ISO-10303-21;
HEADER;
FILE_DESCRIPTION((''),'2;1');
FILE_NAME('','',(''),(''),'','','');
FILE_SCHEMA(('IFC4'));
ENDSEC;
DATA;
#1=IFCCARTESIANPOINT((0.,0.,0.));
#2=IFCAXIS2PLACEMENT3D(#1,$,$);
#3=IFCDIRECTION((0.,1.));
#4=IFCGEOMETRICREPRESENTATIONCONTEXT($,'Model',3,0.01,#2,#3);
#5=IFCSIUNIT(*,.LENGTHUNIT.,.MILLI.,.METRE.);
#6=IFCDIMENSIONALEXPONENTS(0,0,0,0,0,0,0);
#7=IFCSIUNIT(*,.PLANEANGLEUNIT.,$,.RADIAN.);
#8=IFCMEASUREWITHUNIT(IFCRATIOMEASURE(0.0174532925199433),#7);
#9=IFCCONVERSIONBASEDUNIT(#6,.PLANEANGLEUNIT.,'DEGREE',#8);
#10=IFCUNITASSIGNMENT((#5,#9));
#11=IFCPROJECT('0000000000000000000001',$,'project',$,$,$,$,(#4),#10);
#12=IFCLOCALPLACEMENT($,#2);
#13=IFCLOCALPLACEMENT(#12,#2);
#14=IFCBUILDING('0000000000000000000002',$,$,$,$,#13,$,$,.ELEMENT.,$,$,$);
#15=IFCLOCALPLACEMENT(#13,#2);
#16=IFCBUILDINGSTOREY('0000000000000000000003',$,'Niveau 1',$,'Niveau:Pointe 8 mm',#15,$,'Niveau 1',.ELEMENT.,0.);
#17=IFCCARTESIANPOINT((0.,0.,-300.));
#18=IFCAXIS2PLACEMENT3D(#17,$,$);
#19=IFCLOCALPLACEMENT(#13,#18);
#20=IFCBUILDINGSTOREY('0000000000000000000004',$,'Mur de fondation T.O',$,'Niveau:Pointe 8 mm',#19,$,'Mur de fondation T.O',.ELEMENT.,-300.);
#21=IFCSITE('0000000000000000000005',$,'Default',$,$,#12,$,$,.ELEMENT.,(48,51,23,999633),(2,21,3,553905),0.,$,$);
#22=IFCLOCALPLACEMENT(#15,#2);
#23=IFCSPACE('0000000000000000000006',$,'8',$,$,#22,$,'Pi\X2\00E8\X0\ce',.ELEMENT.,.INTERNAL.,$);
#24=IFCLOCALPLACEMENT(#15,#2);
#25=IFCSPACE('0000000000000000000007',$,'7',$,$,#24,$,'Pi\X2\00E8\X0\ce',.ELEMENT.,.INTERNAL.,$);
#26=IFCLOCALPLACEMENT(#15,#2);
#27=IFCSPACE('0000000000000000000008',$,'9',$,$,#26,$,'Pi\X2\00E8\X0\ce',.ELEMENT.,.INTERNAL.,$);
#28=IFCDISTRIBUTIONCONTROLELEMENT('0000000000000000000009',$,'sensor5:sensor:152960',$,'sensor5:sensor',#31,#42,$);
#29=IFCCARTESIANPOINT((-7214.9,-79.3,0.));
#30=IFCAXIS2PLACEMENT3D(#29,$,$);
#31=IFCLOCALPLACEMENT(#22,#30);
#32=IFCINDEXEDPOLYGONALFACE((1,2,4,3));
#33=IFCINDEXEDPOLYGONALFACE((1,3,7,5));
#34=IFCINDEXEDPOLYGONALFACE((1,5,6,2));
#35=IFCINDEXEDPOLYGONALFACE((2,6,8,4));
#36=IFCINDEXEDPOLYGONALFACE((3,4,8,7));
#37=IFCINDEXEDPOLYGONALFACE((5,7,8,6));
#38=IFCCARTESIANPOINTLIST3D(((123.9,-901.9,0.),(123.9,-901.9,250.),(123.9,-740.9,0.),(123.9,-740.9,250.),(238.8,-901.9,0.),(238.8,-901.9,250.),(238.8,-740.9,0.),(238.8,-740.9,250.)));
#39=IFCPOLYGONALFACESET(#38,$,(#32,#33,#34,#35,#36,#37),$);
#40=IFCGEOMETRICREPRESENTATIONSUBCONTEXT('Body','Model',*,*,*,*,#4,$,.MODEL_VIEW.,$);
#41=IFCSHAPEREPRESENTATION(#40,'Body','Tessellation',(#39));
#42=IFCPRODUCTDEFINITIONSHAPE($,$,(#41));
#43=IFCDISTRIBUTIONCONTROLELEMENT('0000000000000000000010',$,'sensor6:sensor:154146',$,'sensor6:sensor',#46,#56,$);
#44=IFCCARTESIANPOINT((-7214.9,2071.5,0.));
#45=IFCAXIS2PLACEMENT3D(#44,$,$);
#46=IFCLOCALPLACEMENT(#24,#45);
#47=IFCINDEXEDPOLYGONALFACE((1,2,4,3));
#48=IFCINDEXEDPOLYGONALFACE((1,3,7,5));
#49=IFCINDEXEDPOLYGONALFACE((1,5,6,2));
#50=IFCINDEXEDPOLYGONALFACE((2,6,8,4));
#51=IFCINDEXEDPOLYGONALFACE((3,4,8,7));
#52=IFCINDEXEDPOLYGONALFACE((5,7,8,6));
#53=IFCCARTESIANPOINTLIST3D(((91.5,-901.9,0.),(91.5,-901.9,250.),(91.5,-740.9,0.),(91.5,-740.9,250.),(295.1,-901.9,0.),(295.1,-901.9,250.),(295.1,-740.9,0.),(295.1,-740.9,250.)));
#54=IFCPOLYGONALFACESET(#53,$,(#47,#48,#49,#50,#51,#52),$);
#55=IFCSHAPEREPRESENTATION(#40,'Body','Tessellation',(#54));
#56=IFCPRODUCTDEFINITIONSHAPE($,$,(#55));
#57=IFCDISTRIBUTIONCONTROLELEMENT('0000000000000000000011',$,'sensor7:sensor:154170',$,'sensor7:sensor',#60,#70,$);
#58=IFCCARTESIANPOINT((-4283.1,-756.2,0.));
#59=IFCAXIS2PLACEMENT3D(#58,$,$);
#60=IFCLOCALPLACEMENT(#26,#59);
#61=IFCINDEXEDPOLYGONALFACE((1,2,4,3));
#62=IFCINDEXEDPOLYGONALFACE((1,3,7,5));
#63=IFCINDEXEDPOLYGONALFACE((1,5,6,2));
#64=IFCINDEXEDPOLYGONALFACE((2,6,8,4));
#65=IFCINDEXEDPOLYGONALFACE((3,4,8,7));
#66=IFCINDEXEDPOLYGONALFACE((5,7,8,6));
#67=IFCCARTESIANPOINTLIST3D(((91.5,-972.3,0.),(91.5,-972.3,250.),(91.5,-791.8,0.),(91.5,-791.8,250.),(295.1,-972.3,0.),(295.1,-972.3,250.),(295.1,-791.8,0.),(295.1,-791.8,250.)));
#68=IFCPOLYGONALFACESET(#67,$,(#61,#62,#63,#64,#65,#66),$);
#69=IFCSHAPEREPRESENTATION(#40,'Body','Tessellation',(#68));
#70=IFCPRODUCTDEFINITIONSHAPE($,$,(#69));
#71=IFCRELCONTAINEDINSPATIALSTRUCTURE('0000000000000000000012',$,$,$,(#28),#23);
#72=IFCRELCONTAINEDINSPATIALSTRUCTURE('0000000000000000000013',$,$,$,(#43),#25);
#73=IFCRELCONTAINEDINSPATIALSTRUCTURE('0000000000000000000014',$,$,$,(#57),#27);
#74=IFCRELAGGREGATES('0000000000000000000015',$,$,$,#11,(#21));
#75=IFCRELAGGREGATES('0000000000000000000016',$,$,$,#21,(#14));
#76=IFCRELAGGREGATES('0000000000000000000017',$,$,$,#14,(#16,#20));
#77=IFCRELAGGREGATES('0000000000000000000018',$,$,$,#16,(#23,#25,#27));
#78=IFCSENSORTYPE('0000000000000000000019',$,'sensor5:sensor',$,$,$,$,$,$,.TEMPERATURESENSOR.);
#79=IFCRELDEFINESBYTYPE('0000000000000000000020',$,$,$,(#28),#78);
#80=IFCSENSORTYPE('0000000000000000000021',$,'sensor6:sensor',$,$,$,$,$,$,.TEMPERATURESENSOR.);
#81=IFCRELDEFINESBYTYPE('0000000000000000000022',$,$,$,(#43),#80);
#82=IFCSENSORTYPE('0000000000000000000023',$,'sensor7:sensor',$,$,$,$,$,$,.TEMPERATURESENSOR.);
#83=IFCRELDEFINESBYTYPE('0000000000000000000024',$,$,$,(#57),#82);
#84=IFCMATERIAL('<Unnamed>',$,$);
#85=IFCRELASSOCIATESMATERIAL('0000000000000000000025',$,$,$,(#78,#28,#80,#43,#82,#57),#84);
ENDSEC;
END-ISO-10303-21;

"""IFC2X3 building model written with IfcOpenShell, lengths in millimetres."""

from ifc_helpers import new_model, entity, si_unit, converted_unit, direction, frame, origin, origin_2d_with_axis, place, context, subcontext, project, spatial, rectangle, extrude, source, transform, mapped, material, type_object, type_shapes, element, save


model = new_model("IFC2X3")

# Units and contexts
model_context = context("Model", 3, precision=0.01, world=origin(), true_north=direction((0.0, 1.0)))
body_context = subcontext(model_context, "Body", "Model", "MODEL_VIEW")
ifc_project = project(units=[si_unit("LENGTHUNIT", "METRE", prefix="MILLI"), converted_unit("PLANEANGLEUNIT", "DEGREE", entity("IfcRatioMeasure", 0.0174532925199433), si_unit("PLANEANGLEUNIT", "RADIAN"), dimensions=[0, 0, 0, 0, 0, 0, 0])], contexts=[model_context])

# Site, building, storey
site_placement = place(None, origin())
site = spatial("IfcSite", under=ifc_project, at=site_placement, Name="Default", CompositionType="ELEMENT", RefLatitude=(48, 51, 23, 999633), RefLongitude=(2, 21, 3, 553905), RefElevation=0.0)
building_placement = place(site_placement, origin())
building = spatial("IfcBuilding", under=site, at=building_placement, CompositionType="ELEMENT")
storey_1_placement = place(building_placement, origin())
storey_1 = spatial("IfcBuildingStorey", under=building, at=storey_1_placement, Name="Niveau 1", ObjectType="Niveau:Pointe 8 mm", LongName="Niveau 1", CompositionType="ELEMENT", Elevation=0.0)

# Shared definitions
storey_2_placement = place(building_placement, frame((0.0, 0.0, -300.0)))
storey_2 = spatial("IfcBuildingStorey", under=building, at=storey_2_placement, Name="Mur de fondation T.O", ObjectType="Niveau:Pointe 8 mm", LongName="Mur de fondation T.O", CompositionType="ELEMENT", Elevation=-300.0)

# Shared definitions
ifc_material_1 = material(Name="<Unnamed>")

# Shared definitions
space_1_placement = place(storey_1_placement, origin())
space_1 = spatial("IfcSpace", under=storey_1, at=space_1_placement, Name="8", LongName="Pièce", CompositionType="ELEMENT", InteriorOrExteriorSpace="INTERNAL")

# Distribution control element
sensor_type_1 = type_object("IfcSensorType", Name="sensor5:sensor", PredefinedType="TEMPERATURESENSOR", material=ifc_material_1)
shared_shape_1 = source(origin(), body_context, "Body", "SweptSolid", [
    extrude(rectangle(XDim=114.9, YDim=161.0, at=origin_2d_with_axis()), frame((181.3, -821.4, 0.0), z_axis=(0.0, 0.0, 1.0), x_axis=(-1.0, 0.0, 0.0)), (0.0, 0.0, 1.0), 250.0),
])
type_shapes(sensor_type_1, [shared_shape_1])
distribution_control_element_1_placement = place(space_1_placement, frame((-7214.9, -79.3, 0.0)))
element("IfcDistributionControlElement", 1, at=distribution_control_element_1_placement, inside=space_1, type_object=sensor_type_1, material=ifc_material_1, Name="sensor5:sensor:152960", ObjectType="sensor5:sensor", context=body_context, shape_type="MappedRepresentation", body=[
    mapped(shared_shape_1, transform((0.0, 0.0, 0.0), scale=1.0)),
])

# Shared definitions
space_2_placement = place(storey_1_placement, origin())
space_2 = spatial("IfcSpace", under=storey_1, at=space_2_placement, Name="7", LongName="Pièce", CompositionType="ELEMENT", InteriorOrExteriorSpace="INTERNAL")

# Distribution control element
sensor_type_2 = type_object("IfcSensorType", Name="sensor6:sensor", PredefinedType="TEMPERATURESENSOR", material=ifc_material_1)
shared_shape_2 = source(origin(), body_context, "Body", "SweptSolid", [
    extrude(rectangle(XDim=203.6, YDim=161.0, at=origin_2d_with_axis()), frame((193.3, -821.4, 0.0), z_axis=(0.0, 0.0, 1.0), x_axis=(-1.0, 0.0, 0.0)), (0.0, 0.0, 1.0), 250.0),
])
type_shapes(sensor_type_2, [shared_shape_2])
distribution_control_element_2_placement = place(space_2_placement, frame((-7214.9, 2071.5, 0.0)))
element("IfcDistributionControlElement", 2, at=distribution_control_element_2_placement, inside=space_2, type_object=sensor_type_2, material=ifc_material_1, Name="sensor6:sensor:154146", ObjectType="sensor6:sensor", context=body_context, shape_type="MappedRepresentation", body=[
    mapped(shared_shape_2, transform((0.0, 0.0, 0.0), scale=1.0)),
])

# Shared definitions
space_3_placement = place(storey_1_placement, origin())
space_3 = spatial("IfcSpace", under=storey_1, at=space_3_placement, Name="9", LongName="Pièce", CompositionType="ELEMENT", InteriorOrExteriorSpace="INTERNAL")

# Distribution control element
sensor_type_3 = type_object("IfcSensorType", Name="sensor7:sensor", PredefinedType="TEMPERATURESENSOR", material=ifc_material_1)
shared_shape_3 = source(origin(), body_context, "Body", "SweptSolid", [
    extrude(rectangle(XDim=203.6, YDim=180.5, at=origin_2d_with_axis()), frame((193.3, -882.0, 0.0), z_axis=(0.0, 0.0, 1.0), x_axis=(-1.0, 0.0, 0.0)), (0.0, 0.0, 1.0), 250.0),
])
type_shapes(sensor_type_3, [shared_shape_3])
distribution_control_element_3_placement = place(space_3_placement, frame((-4283.1, -756.2, 0.0)))
element("IfcDistributionControlElement", 3, at=distribution_control_element_3_placement, inside=space_3, type_object=sensor_type_3, material=ifc_material_1, Name="sensor7:sensor:154170", ObjectType="sensor7:sensor", context=body_context, shape_type="MappedRepresentation", body=[
    mapped(shared_shape_3, transform((0.0, 0.0, 0.0), scale=1.0)),
])

save(model, "model.ifc")
